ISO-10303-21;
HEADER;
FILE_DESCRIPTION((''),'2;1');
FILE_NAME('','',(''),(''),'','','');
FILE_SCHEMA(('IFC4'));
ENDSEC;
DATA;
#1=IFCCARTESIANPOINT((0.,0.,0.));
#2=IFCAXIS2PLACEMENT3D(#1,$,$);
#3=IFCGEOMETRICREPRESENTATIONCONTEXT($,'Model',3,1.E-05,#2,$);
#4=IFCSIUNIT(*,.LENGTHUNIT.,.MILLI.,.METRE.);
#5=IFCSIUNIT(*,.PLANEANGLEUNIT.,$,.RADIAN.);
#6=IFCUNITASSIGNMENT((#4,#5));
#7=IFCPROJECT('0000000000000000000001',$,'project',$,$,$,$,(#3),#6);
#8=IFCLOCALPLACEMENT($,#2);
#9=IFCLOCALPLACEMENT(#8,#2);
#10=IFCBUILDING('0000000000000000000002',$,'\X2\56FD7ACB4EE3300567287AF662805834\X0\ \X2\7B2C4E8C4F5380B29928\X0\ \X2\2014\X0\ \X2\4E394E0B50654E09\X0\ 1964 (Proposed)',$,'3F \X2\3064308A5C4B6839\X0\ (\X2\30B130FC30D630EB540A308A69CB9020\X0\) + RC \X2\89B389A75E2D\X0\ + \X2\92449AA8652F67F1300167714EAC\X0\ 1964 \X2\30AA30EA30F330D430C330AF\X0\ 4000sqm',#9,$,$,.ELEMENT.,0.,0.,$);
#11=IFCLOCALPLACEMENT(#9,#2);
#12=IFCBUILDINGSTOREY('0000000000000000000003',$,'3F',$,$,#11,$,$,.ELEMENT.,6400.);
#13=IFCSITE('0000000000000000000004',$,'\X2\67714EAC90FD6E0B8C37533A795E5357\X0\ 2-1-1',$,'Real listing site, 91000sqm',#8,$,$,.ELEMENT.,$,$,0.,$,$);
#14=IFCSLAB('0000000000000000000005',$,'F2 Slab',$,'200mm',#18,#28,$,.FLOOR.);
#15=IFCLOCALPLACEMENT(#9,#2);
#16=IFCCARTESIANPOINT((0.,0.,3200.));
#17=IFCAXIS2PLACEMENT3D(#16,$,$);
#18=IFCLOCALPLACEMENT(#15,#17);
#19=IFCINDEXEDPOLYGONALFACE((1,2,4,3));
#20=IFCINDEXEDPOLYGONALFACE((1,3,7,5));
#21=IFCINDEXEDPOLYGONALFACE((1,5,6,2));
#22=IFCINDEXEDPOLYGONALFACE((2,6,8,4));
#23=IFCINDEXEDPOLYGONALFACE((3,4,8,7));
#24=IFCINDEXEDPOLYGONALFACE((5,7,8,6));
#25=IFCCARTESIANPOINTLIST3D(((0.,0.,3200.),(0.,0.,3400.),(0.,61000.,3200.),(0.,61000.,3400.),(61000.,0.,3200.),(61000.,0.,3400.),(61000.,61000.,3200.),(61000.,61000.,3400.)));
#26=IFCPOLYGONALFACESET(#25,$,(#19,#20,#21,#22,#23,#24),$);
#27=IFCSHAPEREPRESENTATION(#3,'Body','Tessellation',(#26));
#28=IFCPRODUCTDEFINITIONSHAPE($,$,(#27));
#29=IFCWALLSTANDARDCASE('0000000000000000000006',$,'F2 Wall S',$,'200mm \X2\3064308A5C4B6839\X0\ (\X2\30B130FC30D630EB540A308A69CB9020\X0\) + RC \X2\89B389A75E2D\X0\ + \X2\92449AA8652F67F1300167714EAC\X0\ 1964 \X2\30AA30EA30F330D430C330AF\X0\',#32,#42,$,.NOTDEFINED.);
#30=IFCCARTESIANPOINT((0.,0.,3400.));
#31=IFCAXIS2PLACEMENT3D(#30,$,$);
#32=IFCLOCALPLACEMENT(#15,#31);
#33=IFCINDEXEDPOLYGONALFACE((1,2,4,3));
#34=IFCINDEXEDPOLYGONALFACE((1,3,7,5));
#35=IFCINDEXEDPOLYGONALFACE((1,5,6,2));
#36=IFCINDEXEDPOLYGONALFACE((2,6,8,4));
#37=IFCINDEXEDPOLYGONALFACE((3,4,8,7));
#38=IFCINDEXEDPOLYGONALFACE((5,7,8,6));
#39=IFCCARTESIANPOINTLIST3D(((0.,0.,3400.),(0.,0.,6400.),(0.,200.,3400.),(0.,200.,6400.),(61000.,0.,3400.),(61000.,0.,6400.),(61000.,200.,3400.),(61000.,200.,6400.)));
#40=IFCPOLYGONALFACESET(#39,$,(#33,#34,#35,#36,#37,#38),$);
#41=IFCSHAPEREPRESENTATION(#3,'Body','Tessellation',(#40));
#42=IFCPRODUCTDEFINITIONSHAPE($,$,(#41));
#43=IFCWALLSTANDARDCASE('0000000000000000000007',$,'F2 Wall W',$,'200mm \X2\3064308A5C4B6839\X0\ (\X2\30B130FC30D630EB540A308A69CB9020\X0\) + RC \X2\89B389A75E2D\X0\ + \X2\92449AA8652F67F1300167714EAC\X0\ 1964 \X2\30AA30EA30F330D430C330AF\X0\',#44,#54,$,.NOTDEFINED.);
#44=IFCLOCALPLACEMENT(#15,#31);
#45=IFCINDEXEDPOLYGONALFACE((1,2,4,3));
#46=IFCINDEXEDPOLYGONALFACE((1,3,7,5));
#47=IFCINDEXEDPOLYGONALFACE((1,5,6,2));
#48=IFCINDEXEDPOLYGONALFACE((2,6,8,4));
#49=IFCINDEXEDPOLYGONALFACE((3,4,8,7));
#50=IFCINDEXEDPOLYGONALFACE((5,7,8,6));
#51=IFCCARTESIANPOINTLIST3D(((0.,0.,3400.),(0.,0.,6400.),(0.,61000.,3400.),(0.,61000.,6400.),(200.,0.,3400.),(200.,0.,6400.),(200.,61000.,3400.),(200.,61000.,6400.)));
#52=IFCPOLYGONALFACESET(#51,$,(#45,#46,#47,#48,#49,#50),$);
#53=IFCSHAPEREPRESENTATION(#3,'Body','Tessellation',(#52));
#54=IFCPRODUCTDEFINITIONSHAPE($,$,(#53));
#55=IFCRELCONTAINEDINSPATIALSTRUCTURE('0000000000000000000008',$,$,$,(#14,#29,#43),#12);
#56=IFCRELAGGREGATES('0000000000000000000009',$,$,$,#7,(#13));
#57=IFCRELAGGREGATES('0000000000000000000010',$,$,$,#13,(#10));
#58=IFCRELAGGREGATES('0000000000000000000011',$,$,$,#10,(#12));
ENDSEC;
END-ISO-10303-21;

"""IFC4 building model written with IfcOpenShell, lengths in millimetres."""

from ifc_helpers import new_model, si_unit, frame, frame_2d, origin, place, context, project, spatial, rectangle, extrude, element, save


model = new_model("IFC4")

# Units and contexts
model_context = context("Model", 3, precision=1e-05, world=origin())
ifc_project = project(units=[si_unit("LENGTHUNIT", "METRE", prefix="MILLI"), si_unit("PLANEANGLEUNIT", "RADIAN")], contexts=[model_context])

# Site, building, storey
site_placement = place(None, origin())
site = spatial("IfcSite", under=ifc_project, at=site_placement, Name="東京都渋谷区神南 2-1-1", ObjectType="Real listing site, 91000sqm", CompositionType="ELEMENT", RefElevation=0.0)
building_placement = place(site_placement, origin())
building = spatial("IfcBuilding", under=site, at=building_placement, Name="国立代々木競技場 第二体育館 — 丹下健三 1964 (Proposed)", ObjectType="3F つり屋根 (ケーブル吊り構造) + RC 観覧席 + 鉄骨支柱、東京 1964 オリンピック 4000sqm", CompositionType="ELEMENT", ElevationOfRefHeight=0.0, ElevationOfTerrain=0.0)
storey_placement = place(building_placement, origin())
storey = spatial("IfcBuildingStorey", under=building, at=storey_placement, Name="3F", CompositionType="ELEMENT", Elevation=6400.0)

# Slab
placement = place(building_placement, origin())
slab_placement = place(placement, frame((0.0, 0.0, 3200.0)))
element("IfcSlab", 1, at=slab_placement, inside=storey, Name="F2 Slab", ObjectType="200mm", PredefinedType="FLOOR", context=model_context, shape_type="SweptSolid", body=[
    extrude(rectangle(XDim=61000.0, YDim=61000.0, at=frame_2d((30500.0, 30500.0))), frame((0.0, 0.0, 3200.0)), (0.0, 0.0, 1.0), 200.0),
])

# Walls
wall_1_placement = place(placement, frame((0.0, 0.0, 3400.0)))
element("IfcWallStandardCase", 2, at=wall_1_placement, inside=storey, Name="F2 Wall S", ObjectType="200mm つり屋根 (ケーブル吊り構造) + RC 観覧席 + 鉄骨支柱、東京 1964 オリンピック", PredefinedType="NOTDEFINED", context=model_context, shape_type="SweptSolid", body=[
    extrude(rectangle(XDim=61000.0, YDim=200.0, at=frame_2d((30500.0, 100.0))), frame((0.0, 0.0, 3400.0)), (0.0, 0.0, 1.0), 3000.0),
])
wall_2_placement = place(placement, frame((0.0, 0.0, 3400.0)))
element("IfcWallStandardCase", 3, at=wall_2_placement, inside=storey, Name="F2 Wall W", ObjectType="200mm つり屋根 (ケーブル吊り構造) + RC 観覧席 + 鉄骨支柱、東京 1964 オリンピック", PredefinedType="NOTDEFINED", context=model_context, shape_type="SweptSolid", body=[
    extrude(rectangle(XDim=200.0, YDim=61000.0, at=frame_2d((100.0, 30500.0))), frame((0.0, 0.0, 3400.0)), (0.0, 0.0, 1.0), 3000.0),
])

save(model, "model.ifc")
